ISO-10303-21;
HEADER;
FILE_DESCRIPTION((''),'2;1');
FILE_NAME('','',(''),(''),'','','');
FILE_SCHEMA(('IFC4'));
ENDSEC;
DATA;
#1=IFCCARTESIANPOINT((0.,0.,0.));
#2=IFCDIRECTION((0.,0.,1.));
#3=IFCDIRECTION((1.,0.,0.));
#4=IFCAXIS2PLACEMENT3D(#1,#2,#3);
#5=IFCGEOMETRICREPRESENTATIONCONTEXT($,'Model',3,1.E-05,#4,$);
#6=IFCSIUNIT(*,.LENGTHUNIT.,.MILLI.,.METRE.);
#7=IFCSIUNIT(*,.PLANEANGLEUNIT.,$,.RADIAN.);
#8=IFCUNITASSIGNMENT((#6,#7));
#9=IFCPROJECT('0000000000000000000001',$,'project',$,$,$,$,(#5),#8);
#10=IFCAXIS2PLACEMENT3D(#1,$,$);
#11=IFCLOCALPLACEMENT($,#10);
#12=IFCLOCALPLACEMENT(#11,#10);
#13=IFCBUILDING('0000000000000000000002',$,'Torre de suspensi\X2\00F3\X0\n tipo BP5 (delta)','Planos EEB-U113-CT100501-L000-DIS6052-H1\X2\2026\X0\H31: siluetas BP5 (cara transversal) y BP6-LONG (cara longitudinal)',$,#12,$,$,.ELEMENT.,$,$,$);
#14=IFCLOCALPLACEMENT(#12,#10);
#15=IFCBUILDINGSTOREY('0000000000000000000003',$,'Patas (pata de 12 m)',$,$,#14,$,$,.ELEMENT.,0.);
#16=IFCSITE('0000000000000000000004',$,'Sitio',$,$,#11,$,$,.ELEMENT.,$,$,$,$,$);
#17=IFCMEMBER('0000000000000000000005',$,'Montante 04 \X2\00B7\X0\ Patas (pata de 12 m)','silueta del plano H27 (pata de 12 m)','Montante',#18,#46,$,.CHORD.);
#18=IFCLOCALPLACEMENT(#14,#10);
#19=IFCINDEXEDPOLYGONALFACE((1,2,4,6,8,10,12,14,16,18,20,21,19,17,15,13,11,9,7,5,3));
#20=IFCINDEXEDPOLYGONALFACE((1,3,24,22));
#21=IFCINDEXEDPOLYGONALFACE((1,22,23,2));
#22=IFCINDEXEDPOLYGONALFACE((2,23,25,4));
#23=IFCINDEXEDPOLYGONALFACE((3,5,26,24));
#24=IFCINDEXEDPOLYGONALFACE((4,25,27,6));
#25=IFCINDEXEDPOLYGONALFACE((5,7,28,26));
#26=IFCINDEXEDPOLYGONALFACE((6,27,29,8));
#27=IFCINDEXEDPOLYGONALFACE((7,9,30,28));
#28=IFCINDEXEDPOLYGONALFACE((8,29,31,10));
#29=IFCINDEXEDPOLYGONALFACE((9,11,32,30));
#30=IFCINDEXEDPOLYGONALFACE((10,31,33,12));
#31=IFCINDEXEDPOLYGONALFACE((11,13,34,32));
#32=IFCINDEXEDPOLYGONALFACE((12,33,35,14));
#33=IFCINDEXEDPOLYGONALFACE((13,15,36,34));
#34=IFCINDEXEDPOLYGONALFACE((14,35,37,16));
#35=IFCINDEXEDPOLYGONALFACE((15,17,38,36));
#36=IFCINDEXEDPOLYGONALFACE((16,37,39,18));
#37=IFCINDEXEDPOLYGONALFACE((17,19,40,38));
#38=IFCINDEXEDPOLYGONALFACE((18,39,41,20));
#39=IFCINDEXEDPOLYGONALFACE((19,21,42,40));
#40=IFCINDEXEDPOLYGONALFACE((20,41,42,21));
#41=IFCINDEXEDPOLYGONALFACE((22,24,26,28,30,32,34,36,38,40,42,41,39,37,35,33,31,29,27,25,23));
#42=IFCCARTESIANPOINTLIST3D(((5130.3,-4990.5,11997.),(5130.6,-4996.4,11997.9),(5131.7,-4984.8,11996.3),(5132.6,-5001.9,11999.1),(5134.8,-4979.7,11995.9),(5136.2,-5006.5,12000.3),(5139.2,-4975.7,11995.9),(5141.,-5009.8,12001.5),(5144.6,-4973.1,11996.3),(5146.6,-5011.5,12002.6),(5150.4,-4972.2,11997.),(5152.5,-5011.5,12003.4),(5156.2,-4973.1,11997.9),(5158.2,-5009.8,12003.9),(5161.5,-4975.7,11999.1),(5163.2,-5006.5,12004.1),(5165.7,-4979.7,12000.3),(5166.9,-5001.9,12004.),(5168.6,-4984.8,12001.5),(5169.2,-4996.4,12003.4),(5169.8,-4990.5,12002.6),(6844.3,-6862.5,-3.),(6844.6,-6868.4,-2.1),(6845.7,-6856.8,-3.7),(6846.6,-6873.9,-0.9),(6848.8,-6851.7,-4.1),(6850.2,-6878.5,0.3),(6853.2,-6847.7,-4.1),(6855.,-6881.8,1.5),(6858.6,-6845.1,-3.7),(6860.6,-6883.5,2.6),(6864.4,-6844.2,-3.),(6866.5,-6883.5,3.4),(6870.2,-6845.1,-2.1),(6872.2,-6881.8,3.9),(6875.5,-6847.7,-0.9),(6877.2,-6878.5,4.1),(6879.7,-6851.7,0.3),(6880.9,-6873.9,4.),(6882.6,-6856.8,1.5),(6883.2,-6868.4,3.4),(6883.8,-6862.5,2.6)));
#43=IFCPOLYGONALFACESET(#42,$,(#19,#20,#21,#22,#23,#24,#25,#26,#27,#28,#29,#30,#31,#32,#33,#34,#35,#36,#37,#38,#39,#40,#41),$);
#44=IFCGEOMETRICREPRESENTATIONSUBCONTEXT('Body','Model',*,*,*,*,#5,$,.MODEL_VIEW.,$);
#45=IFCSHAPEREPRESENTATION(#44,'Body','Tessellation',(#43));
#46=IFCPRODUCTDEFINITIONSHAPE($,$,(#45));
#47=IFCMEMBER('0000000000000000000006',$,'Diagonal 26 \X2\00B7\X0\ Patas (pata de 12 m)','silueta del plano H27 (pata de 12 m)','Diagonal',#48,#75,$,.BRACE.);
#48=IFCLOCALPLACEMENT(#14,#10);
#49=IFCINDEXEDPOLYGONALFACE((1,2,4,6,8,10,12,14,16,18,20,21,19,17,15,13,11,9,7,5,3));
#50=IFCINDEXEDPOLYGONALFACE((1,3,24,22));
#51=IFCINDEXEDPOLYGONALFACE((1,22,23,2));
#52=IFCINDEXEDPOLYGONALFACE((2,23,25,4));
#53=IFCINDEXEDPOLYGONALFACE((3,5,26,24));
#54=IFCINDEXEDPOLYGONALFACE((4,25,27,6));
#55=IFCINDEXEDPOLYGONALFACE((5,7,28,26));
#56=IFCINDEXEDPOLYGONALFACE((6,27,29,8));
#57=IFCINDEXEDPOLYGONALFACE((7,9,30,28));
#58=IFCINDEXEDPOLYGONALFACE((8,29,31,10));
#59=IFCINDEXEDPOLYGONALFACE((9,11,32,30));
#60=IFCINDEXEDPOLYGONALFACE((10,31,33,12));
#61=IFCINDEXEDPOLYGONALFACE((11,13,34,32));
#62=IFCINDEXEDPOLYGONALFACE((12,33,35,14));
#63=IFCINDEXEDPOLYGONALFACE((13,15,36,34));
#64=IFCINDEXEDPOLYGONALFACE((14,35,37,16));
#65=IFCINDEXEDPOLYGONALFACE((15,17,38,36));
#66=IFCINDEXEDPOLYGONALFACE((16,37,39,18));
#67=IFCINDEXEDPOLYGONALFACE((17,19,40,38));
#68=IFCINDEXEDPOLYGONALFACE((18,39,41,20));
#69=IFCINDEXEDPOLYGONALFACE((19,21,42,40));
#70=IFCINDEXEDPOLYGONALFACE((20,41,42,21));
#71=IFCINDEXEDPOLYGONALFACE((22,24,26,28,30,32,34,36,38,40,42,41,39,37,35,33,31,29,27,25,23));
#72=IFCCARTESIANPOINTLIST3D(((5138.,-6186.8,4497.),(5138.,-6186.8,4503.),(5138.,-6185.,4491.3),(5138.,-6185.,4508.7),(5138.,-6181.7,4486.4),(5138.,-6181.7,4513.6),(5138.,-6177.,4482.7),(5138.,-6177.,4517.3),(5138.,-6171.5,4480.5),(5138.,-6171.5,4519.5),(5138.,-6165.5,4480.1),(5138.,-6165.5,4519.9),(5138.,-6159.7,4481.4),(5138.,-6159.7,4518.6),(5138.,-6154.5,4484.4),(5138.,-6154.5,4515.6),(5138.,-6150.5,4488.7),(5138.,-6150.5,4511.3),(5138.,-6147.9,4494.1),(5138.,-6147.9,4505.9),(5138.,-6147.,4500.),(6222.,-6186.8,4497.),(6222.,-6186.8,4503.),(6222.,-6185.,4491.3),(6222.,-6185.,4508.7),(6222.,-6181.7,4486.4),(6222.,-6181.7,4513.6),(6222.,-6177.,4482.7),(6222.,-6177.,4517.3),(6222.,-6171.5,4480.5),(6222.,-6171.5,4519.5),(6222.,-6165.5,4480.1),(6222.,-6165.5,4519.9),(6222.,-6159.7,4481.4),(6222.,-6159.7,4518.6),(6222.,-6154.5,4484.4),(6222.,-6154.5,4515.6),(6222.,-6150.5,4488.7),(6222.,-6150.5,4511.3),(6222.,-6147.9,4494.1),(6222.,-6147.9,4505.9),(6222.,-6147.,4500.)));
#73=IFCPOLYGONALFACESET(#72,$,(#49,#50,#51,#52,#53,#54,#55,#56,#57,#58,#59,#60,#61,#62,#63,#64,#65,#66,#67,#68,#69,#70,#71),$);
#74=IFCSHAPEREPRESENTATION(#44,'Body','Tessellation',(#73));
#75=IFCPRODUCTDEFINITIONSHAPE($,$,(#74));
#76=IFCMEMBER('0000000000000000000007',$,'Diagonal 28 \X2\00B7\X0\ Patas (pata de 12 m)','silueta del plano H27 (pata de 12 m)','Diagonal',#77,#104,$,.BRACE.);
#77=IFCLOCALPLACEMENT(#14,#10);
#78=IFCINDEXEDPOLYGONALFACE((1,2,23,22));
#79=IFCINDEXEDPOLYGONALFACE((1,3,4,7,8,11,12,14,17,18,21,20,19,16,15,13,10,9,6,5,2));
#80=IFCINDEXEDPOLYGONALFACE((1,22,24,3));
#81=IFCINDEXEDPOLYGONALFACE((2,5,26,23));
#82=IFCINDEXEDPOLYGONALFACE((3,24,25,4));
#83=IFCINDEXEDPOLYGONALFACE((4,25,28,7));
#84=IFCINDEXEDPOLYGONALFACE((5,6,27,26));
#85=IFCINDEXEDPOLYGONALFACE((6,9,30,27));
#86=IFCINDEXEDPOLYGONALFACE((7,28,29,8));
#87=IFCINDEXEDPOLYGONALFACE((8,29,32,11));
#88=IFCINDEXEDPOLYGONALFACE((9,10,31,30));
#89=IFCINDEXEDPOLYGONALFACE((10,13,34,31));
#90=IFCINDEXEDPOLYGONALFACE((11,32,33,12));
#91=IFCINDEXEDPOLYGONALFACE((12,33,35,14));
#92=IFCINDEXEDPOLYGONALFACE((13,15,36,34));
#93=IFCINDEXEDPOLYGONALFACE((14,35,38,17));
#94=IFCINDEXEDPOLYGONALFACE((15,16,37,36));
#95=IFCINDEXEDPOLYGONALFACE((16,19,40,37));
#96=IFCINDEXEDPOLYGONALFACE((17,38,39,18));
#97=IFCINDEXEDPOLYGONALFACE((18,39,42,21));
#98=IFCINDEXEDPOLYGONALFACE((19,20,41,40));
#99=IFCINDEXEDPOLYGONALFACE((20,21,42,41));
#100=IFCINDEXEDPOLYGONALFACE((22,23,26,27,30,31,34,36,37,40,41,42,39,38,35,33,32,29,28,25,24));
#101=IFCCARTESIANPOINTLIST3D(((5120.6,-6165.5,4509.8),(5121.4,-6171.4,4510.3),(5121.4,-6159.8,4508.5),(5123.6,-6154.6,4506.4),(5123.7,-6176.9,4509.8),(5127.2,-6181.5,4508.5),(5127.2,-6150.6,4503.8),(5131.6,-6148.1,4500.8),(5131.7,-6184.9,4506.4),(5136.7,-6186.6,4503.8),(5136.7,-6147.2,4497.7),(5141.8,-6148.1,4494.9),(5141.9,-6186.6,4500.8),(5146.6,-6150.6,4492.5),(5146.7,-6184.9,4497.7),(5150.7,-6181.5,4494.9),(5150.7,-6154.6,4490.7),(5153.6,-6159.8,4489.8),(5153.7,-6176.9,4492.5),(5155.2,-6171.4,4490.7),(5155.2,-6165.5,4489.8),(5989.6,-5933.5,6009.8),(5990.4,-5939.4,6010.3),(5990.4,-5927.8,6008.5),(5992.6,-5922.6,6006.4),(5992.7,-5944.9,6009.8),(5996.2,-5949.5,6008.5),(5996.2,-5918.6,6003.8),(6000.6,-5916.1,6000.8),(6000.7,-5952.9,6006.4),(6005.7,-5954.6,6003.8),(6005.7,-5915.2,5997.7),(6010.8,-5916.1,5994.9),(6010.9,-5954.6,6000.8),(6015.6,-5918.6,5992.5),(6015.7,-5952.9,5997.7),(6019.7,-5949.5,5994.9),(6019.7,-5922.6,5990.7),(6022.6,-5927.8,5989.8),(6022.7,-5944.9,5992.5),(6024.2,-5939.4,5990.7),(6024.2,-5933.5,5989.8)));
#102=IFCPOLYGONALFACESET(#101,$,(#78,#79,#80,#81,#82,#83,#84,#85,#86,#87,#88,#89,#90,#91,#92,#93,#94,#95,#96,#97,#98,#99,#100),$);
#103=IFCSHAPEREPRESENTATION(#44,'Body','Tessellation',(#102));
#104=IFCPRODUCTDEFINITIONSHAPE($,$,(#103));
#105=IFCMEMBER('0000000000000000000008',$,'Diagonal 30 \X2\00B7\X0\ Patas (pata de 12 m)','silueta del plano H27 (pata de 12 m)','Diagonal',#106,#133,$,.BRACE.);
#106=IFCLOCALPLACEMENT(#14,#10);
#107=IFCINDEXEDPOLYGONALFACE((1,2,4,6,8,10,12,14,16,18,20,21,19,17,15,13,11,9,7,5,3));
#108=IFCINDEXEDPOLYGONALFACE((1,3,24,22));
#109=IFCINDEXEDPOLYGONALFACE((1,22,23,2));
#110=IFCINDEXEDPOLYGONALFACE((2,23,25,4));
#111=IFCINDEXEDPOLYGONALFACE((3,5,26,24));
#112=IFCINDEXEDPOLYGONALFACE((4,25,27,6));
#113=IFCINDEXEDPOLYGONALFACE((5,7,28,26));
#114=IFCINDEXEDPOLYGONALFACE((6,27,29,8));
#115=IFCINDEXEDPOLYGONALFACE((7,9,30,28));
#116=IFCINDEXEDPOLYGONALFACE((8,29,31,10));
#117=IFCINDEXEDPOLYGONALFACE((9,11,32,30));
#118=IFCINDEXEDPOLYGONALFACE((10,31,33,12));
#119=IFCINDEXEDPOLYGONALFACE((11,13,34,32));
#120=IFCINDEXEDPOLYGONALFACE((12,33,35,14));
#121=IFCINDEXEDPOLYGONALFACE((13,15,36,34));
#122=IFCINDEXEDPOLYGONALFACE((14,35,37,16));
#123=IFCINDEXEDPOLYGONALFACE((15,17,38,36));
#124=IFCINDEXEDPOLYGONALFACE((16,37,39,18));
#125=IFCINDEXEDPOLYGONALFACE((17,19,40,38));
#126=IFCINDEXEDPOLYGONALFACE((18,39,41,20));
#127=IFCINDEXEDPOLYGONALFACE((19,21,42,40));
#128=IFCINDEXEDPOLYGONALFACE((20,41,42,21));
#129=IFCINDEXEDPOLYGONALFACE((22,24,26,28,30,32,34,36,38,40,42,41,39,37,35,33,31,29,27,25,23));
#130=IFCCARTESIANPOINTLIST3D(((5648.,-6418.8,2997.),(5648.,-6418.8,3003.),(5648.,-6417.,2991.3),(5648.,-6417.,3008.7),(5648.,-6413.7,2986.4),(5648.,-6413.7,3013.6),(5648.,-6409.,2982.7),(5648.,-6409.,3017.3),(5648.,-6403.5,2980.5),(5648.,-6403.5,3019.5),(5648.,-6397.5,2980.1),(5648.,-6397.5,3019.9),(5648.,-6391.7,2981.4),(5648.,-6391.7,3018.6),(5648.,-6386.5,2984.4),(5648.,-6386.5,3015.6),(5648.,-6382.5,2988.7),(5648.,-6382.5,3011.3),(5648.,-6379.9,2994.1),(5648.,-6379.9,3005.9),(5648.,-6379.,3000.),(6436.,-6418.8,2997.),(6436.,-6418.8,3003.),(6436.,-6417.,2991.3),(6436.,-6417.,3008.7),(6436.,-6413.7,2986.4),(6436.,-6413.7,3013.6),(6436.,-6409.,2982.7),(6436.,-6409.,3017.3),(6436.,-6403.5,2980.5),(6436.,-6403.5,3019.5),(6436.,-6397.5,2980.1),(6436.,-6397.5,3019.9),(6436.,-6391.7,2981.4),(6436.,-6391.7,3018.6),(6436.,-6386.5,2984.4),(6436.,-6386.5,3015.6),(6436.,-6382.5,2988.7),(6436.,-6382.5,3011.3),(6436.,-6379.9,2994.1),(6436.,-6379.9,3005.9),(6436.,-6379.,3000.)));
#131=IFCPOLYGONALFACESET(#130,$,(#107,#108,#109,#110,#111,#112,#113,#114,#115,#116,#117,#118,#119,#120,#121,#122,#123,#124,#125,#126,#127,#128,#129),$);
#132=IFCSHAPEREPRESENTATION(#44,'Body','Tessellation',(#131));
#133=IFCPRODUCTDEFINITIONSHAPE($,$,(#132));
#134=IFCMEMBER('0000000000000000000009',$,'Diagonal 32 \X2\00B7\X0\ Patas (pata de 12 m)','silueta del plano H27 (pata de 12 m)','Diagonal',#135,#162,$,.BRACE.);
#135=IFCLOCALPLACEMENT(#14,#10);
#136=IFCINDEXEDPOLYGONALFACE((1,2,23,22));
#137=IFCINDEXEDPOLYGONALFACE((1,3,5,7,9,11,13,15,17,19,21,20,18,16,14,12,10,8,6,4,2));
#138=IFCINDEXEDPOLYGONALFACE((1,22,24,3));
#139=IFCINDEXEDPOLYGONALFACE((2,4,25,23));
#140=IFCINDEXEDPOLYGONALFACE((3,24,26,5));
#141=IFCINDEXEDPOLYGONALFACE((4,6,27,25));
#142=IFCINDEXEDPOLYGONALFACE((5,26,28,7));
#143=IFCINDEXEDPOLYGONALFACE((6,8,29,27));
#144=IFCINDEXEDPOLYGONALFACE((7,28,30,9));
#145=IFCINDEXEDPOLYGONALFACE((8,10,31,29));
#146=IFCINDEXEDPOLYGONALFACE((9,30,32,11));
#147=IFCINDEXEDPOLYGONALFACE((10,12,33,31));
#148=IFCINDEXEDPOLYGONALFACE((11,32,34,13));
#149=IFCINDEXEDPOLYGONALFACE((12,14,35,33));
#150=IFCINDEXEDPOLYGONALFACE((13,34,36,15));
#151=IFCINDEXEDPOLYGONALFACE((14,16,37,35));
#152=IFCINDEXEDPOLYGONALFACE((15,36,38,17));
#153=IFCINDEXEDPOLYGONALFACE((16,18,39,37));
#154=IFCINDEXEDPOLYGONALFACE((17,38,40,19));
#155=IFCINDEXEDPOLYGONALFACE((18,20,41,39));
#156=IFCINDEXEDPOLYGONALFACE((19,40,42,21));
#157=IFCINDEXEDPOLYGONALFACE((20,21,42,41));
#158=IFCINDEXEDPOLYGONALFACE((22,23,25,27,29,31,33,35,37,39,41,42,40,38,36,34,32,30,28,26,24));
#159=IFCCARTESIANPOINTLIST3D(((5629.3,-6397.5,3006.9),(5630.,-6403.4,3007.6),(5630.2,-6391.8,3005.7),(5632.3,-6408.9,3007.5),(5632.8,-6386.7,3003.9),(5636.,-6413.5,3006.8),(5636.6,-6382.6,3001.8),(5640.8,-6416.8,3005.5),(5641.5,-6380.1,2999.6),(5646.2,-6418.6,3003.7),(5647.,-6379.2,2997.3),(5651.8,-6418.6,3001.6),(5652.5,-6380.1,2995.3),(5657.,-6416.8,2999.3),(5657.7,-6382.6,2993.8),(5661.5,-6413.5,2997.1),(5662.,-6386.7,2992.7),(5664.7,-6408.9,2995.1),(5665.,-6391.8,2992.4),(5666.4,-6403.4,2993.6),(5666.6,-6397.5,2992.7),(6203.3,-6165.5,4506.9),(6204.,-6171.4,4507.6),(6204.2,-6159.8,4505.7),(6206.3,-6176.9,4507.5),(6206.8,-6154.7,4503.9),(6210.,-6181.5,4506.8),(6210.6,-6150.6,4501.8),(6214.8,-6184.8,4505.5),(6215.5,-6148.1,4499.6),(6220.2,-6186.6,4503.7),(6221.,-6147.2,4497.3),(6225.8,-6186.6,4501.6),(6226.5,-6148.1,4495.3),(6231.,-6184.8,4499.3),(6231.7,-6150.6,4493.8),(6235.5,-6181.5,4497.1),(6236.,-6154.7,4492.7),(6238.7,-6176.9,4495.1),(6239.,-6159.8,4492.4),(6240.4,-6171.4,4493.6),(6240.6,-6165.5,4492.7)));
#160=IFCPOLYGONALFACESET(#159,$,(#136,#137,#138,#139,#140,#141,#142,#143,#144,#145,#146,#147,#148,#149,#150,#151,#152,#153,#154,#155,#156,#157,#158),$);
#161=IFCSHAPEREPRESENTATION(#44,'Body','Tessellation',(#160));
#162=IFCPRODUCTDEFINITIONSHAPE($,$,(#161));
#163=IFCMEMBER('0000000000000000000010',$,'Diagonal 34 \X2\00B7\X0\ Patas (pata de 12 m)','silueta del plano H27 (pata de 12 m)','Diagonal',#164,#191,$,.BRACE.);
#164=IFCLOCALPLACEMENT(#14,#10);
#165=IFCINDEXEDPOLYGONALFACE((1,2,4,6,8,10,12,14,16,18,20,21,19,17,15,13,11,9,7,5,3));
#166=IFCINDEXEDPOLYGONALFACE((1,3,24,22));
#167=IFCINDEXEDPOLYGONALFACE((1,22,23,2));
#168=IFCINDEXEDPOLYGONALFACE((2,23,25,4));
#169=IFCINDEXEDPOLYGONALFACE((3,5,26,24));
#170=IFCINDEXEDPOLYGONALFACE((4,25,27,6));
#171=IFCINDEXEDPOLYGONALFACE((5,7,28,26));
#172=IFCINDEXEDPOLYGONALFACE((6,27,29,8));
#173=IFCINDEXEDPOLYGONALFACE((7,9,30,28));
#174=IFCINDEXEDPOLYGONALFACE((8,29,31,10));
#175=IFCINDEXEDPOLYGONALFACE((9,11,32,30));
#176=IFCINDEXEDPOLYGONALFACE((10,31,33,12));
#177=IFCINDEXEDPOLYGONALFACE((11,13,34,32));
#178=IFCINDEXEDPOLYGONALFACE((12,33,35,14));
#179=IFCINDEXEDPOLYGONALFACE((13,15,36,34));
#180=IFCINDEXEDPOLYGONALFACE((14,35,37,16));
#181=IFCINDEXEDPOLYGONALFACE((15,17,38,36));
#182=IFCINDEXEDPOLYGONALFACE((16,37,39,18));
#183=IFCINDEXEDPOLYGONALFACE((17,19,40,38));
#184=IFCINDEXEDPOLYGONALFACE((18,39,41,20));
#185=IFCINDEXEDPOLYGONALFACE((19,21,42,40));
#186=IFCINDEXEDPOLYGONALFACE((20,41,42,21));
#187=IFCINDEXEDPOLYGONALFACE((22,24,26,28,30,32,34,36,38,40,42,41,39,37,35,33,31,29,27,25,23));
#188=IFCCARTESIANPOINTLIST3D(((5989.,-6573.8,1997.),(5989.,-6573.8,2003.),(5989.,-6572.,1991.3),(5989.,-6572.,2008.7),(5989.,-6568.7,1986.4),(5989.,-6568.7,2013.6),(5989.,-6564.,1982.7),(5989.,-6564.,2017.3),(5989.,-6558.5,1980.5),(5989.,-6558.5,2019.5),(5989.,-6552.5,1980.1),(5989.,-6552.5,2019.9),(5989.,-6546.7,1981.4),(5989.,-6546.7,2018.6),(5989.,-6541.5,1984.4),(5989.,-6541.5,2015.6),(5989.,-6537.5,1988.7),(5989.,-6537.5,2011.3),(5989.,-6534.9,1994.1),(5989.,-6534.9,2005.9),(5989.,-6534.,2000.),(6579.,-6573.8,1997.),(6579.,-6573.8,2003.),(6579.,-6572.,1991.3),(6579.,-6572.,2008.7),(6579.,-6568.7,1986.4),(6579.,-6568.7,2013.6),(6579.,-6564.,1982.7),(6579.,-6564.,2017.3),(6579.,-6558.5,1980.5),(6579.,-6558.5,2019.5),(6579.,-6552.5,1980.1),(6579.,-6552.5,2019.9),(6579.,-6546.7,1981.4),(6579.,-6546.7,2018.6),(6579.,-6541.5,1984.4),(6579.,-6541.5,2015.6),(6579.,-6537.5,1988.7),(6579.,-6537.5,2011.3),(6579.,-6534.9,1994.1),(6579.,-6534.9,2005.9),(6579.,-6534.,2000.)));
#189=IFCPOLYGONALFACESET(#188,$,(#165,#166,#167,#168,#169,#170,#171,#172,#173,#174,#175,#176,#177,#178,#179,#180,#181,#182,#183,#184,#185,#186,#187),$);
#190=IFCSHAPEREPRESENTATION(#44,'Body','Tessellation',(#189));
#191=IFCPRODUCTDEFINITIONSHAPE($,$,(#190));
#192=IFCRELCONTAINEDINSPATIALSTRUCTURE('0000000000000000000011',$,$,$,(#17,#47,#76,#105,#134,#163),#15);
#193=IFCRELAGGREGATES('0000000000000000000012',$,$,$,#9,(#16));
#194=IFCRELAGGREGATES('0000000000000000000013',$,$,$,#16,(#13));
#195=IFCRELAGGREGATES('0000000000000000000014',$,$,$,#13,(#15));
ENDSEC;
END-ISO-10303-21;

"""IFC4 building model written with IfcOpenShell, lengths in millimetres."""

from ifc_helpers import new_model, si_unit, frame, origin, origin_with_axes, place, context, subcontext, project, spatial, circle, extrude, element, save


model = new_model("IFC4")

# Units and contexts
model_context = context("Model", 3, precision=1e-05, world=origin_with_axes())
body_context = subcontext(model_context, "Body", "Model", "MODEL_VIEW")
ifc_project = project(units=[si_unit("LENGTHUNIT", "METRE", prefix="MILLI"), si_unit("PLANEANGLEUNIT", "RADIAN")], contexts=[model_context])

# Site, building, storey
site_placement = place(None, origin())
site = spatial("IfcSite", under=ifc_project, at=site_placement, Name="Sitio", CompositionType="ELEMENT")
building_placement = place(site_placement, origin())
building = spatial("IfcBuilding", under=site, at=building_placement, Name="Torre de suspensión tipo BP5 (delta)", Description="Planos EEB-U113-CT100501-L000-DIS6052-H1…H31: siluetas BP5 (cara transversal) y BP6-LONG (cara longitudinal)", CompositionType="ELEMENT")
storey_placement = place(building_placement, origin())
storey = spatial("IfcBuildingStorey", under=building, at=storey_placement, Name="Patas (pata de 12 m)", CompositionType="ELEMENT", Elevation=0.0)

# Members
member_1_placement = place(storey_placement, frame((6864.0, -6864.0, 0.0), z_axis=(-0.139742, 0.152623, 0.978355), x_axis=(0.021581, 0.988284, -0.15109)))
element("IfcMember", 1, at=member_1_placement, inside=storey, Name="Montante 04 · Patas (pata de 12 m)", Description="silueta del plano H27 (pata de 12 m)", ObjectType="Montante", PredefinedType="CHORD", context=body_context, shape_type="SweptSolid", body=[
    extrude(circle(Radius=20.0), None, (0.0, 0.0, 1.0), 12265.5),
])
member_2_placement = place(storey_placement, frame((6222.0, -6167.0, 4500.0), z_axis=(-1.0, 0.0, 0.0), x_axis=(0.0, 1.0, 0.0)))
element("IfcMember", 2, at=member_2_placement, inside=storey, Name="Diagonal 26 · Patas (pata de 12 m)", Description="silueta del plano H27 (pata de 12 m)", ObjectType="Diagonal", PredefinedType="BRACE", context=body_context, shape_type="SweptSolid", body=[
    extrude(circle(Radius=20.0), None, (0.0, 0.0, 1.0), 1084.0),
])
member_3_placement = place(storey_placement, frame((5138.0, -6167.0, 4500.0), z_axis=(0.496857, 0.132648, 0.857635), x_axis=(-0.066494, 0.991163, -0.114777)))
element("IfcMember", 3, at=member_3_placement, inside=storey, Name="Diagonal 28 · Patas (pata de 12 m)", Description="silueta del plano H27 (pata de 12 m)", ObjectType="Diagonal", PredefinedType="BRACE", context=body_context, shape_type="SweptSolid", body=[
    extrude(circle(Radius=20.0), None, (0.0, 0.0, 1.0), 1749.0),
])
member_4_placement = place(storey_placement, frame((6436.0, -6399.0, 3000.0), z_axis=(-1.0, 0.0, 0.0), x_axis=(0.0, 1.0, 0.0)))
element("IfcMember", 4, at=member_4_placement, inside=storey, Name="Diagonal 30 · Patas (pata de 12 m)", Description="silueta del plano H27 (pata de 12 m)", ObjectType="Diagonal", PredefinedType="BRACE", context=body_context, shape_type="SweptSolid", body=[
    extrude(circle(Radius=20.0), None, (0.0, 0.0, 1.0), 788.0),
])
member_5_placement = place(storey_placement, frame((5648.0, -6399.0, 3000.0), z_axis=(0.353722, 0.142968, 0.92436), x_axis=(-0.051096, 0.989727, -0.133525)))
element("IfcMember", 5, at=member_5_placement, inside=storey, Name="Diagonal 32 · Patas (pata de 12 m)", Description="silueta del plano H27 (pata de 12 m)", ObjectType="Diagonal", PredefinedType="BRACE", context=body_context, shape_type="SweptSolid", body=[
    extrude(circle(Radius=20.0), None, (0.0, 0.0, 1.0), 1622.7),
])
member_6_placement = place(storey_placement, frame((6579.0, -6554.0, 2000.0), z_axis=(-1.0, 0.0, 0.0), x_axis=(0.0, 1.0, 0.0)))
element("IfcMember", 6, at=member_6_placement, inside=storey, Name="Diagonal 34 · Patas (pata de 12 m)", Description="silueta del plano H27 (pata de 12 m)", ObjectType="Diagonal", PredefinedType="BRACE", context=body_context, shape_type="SweptSolid", body=[
    extrude(circle(Radius=20.0), None, (0.0, 0.0, 1.0), 590.0),
])

save(model, "model.ifc")
